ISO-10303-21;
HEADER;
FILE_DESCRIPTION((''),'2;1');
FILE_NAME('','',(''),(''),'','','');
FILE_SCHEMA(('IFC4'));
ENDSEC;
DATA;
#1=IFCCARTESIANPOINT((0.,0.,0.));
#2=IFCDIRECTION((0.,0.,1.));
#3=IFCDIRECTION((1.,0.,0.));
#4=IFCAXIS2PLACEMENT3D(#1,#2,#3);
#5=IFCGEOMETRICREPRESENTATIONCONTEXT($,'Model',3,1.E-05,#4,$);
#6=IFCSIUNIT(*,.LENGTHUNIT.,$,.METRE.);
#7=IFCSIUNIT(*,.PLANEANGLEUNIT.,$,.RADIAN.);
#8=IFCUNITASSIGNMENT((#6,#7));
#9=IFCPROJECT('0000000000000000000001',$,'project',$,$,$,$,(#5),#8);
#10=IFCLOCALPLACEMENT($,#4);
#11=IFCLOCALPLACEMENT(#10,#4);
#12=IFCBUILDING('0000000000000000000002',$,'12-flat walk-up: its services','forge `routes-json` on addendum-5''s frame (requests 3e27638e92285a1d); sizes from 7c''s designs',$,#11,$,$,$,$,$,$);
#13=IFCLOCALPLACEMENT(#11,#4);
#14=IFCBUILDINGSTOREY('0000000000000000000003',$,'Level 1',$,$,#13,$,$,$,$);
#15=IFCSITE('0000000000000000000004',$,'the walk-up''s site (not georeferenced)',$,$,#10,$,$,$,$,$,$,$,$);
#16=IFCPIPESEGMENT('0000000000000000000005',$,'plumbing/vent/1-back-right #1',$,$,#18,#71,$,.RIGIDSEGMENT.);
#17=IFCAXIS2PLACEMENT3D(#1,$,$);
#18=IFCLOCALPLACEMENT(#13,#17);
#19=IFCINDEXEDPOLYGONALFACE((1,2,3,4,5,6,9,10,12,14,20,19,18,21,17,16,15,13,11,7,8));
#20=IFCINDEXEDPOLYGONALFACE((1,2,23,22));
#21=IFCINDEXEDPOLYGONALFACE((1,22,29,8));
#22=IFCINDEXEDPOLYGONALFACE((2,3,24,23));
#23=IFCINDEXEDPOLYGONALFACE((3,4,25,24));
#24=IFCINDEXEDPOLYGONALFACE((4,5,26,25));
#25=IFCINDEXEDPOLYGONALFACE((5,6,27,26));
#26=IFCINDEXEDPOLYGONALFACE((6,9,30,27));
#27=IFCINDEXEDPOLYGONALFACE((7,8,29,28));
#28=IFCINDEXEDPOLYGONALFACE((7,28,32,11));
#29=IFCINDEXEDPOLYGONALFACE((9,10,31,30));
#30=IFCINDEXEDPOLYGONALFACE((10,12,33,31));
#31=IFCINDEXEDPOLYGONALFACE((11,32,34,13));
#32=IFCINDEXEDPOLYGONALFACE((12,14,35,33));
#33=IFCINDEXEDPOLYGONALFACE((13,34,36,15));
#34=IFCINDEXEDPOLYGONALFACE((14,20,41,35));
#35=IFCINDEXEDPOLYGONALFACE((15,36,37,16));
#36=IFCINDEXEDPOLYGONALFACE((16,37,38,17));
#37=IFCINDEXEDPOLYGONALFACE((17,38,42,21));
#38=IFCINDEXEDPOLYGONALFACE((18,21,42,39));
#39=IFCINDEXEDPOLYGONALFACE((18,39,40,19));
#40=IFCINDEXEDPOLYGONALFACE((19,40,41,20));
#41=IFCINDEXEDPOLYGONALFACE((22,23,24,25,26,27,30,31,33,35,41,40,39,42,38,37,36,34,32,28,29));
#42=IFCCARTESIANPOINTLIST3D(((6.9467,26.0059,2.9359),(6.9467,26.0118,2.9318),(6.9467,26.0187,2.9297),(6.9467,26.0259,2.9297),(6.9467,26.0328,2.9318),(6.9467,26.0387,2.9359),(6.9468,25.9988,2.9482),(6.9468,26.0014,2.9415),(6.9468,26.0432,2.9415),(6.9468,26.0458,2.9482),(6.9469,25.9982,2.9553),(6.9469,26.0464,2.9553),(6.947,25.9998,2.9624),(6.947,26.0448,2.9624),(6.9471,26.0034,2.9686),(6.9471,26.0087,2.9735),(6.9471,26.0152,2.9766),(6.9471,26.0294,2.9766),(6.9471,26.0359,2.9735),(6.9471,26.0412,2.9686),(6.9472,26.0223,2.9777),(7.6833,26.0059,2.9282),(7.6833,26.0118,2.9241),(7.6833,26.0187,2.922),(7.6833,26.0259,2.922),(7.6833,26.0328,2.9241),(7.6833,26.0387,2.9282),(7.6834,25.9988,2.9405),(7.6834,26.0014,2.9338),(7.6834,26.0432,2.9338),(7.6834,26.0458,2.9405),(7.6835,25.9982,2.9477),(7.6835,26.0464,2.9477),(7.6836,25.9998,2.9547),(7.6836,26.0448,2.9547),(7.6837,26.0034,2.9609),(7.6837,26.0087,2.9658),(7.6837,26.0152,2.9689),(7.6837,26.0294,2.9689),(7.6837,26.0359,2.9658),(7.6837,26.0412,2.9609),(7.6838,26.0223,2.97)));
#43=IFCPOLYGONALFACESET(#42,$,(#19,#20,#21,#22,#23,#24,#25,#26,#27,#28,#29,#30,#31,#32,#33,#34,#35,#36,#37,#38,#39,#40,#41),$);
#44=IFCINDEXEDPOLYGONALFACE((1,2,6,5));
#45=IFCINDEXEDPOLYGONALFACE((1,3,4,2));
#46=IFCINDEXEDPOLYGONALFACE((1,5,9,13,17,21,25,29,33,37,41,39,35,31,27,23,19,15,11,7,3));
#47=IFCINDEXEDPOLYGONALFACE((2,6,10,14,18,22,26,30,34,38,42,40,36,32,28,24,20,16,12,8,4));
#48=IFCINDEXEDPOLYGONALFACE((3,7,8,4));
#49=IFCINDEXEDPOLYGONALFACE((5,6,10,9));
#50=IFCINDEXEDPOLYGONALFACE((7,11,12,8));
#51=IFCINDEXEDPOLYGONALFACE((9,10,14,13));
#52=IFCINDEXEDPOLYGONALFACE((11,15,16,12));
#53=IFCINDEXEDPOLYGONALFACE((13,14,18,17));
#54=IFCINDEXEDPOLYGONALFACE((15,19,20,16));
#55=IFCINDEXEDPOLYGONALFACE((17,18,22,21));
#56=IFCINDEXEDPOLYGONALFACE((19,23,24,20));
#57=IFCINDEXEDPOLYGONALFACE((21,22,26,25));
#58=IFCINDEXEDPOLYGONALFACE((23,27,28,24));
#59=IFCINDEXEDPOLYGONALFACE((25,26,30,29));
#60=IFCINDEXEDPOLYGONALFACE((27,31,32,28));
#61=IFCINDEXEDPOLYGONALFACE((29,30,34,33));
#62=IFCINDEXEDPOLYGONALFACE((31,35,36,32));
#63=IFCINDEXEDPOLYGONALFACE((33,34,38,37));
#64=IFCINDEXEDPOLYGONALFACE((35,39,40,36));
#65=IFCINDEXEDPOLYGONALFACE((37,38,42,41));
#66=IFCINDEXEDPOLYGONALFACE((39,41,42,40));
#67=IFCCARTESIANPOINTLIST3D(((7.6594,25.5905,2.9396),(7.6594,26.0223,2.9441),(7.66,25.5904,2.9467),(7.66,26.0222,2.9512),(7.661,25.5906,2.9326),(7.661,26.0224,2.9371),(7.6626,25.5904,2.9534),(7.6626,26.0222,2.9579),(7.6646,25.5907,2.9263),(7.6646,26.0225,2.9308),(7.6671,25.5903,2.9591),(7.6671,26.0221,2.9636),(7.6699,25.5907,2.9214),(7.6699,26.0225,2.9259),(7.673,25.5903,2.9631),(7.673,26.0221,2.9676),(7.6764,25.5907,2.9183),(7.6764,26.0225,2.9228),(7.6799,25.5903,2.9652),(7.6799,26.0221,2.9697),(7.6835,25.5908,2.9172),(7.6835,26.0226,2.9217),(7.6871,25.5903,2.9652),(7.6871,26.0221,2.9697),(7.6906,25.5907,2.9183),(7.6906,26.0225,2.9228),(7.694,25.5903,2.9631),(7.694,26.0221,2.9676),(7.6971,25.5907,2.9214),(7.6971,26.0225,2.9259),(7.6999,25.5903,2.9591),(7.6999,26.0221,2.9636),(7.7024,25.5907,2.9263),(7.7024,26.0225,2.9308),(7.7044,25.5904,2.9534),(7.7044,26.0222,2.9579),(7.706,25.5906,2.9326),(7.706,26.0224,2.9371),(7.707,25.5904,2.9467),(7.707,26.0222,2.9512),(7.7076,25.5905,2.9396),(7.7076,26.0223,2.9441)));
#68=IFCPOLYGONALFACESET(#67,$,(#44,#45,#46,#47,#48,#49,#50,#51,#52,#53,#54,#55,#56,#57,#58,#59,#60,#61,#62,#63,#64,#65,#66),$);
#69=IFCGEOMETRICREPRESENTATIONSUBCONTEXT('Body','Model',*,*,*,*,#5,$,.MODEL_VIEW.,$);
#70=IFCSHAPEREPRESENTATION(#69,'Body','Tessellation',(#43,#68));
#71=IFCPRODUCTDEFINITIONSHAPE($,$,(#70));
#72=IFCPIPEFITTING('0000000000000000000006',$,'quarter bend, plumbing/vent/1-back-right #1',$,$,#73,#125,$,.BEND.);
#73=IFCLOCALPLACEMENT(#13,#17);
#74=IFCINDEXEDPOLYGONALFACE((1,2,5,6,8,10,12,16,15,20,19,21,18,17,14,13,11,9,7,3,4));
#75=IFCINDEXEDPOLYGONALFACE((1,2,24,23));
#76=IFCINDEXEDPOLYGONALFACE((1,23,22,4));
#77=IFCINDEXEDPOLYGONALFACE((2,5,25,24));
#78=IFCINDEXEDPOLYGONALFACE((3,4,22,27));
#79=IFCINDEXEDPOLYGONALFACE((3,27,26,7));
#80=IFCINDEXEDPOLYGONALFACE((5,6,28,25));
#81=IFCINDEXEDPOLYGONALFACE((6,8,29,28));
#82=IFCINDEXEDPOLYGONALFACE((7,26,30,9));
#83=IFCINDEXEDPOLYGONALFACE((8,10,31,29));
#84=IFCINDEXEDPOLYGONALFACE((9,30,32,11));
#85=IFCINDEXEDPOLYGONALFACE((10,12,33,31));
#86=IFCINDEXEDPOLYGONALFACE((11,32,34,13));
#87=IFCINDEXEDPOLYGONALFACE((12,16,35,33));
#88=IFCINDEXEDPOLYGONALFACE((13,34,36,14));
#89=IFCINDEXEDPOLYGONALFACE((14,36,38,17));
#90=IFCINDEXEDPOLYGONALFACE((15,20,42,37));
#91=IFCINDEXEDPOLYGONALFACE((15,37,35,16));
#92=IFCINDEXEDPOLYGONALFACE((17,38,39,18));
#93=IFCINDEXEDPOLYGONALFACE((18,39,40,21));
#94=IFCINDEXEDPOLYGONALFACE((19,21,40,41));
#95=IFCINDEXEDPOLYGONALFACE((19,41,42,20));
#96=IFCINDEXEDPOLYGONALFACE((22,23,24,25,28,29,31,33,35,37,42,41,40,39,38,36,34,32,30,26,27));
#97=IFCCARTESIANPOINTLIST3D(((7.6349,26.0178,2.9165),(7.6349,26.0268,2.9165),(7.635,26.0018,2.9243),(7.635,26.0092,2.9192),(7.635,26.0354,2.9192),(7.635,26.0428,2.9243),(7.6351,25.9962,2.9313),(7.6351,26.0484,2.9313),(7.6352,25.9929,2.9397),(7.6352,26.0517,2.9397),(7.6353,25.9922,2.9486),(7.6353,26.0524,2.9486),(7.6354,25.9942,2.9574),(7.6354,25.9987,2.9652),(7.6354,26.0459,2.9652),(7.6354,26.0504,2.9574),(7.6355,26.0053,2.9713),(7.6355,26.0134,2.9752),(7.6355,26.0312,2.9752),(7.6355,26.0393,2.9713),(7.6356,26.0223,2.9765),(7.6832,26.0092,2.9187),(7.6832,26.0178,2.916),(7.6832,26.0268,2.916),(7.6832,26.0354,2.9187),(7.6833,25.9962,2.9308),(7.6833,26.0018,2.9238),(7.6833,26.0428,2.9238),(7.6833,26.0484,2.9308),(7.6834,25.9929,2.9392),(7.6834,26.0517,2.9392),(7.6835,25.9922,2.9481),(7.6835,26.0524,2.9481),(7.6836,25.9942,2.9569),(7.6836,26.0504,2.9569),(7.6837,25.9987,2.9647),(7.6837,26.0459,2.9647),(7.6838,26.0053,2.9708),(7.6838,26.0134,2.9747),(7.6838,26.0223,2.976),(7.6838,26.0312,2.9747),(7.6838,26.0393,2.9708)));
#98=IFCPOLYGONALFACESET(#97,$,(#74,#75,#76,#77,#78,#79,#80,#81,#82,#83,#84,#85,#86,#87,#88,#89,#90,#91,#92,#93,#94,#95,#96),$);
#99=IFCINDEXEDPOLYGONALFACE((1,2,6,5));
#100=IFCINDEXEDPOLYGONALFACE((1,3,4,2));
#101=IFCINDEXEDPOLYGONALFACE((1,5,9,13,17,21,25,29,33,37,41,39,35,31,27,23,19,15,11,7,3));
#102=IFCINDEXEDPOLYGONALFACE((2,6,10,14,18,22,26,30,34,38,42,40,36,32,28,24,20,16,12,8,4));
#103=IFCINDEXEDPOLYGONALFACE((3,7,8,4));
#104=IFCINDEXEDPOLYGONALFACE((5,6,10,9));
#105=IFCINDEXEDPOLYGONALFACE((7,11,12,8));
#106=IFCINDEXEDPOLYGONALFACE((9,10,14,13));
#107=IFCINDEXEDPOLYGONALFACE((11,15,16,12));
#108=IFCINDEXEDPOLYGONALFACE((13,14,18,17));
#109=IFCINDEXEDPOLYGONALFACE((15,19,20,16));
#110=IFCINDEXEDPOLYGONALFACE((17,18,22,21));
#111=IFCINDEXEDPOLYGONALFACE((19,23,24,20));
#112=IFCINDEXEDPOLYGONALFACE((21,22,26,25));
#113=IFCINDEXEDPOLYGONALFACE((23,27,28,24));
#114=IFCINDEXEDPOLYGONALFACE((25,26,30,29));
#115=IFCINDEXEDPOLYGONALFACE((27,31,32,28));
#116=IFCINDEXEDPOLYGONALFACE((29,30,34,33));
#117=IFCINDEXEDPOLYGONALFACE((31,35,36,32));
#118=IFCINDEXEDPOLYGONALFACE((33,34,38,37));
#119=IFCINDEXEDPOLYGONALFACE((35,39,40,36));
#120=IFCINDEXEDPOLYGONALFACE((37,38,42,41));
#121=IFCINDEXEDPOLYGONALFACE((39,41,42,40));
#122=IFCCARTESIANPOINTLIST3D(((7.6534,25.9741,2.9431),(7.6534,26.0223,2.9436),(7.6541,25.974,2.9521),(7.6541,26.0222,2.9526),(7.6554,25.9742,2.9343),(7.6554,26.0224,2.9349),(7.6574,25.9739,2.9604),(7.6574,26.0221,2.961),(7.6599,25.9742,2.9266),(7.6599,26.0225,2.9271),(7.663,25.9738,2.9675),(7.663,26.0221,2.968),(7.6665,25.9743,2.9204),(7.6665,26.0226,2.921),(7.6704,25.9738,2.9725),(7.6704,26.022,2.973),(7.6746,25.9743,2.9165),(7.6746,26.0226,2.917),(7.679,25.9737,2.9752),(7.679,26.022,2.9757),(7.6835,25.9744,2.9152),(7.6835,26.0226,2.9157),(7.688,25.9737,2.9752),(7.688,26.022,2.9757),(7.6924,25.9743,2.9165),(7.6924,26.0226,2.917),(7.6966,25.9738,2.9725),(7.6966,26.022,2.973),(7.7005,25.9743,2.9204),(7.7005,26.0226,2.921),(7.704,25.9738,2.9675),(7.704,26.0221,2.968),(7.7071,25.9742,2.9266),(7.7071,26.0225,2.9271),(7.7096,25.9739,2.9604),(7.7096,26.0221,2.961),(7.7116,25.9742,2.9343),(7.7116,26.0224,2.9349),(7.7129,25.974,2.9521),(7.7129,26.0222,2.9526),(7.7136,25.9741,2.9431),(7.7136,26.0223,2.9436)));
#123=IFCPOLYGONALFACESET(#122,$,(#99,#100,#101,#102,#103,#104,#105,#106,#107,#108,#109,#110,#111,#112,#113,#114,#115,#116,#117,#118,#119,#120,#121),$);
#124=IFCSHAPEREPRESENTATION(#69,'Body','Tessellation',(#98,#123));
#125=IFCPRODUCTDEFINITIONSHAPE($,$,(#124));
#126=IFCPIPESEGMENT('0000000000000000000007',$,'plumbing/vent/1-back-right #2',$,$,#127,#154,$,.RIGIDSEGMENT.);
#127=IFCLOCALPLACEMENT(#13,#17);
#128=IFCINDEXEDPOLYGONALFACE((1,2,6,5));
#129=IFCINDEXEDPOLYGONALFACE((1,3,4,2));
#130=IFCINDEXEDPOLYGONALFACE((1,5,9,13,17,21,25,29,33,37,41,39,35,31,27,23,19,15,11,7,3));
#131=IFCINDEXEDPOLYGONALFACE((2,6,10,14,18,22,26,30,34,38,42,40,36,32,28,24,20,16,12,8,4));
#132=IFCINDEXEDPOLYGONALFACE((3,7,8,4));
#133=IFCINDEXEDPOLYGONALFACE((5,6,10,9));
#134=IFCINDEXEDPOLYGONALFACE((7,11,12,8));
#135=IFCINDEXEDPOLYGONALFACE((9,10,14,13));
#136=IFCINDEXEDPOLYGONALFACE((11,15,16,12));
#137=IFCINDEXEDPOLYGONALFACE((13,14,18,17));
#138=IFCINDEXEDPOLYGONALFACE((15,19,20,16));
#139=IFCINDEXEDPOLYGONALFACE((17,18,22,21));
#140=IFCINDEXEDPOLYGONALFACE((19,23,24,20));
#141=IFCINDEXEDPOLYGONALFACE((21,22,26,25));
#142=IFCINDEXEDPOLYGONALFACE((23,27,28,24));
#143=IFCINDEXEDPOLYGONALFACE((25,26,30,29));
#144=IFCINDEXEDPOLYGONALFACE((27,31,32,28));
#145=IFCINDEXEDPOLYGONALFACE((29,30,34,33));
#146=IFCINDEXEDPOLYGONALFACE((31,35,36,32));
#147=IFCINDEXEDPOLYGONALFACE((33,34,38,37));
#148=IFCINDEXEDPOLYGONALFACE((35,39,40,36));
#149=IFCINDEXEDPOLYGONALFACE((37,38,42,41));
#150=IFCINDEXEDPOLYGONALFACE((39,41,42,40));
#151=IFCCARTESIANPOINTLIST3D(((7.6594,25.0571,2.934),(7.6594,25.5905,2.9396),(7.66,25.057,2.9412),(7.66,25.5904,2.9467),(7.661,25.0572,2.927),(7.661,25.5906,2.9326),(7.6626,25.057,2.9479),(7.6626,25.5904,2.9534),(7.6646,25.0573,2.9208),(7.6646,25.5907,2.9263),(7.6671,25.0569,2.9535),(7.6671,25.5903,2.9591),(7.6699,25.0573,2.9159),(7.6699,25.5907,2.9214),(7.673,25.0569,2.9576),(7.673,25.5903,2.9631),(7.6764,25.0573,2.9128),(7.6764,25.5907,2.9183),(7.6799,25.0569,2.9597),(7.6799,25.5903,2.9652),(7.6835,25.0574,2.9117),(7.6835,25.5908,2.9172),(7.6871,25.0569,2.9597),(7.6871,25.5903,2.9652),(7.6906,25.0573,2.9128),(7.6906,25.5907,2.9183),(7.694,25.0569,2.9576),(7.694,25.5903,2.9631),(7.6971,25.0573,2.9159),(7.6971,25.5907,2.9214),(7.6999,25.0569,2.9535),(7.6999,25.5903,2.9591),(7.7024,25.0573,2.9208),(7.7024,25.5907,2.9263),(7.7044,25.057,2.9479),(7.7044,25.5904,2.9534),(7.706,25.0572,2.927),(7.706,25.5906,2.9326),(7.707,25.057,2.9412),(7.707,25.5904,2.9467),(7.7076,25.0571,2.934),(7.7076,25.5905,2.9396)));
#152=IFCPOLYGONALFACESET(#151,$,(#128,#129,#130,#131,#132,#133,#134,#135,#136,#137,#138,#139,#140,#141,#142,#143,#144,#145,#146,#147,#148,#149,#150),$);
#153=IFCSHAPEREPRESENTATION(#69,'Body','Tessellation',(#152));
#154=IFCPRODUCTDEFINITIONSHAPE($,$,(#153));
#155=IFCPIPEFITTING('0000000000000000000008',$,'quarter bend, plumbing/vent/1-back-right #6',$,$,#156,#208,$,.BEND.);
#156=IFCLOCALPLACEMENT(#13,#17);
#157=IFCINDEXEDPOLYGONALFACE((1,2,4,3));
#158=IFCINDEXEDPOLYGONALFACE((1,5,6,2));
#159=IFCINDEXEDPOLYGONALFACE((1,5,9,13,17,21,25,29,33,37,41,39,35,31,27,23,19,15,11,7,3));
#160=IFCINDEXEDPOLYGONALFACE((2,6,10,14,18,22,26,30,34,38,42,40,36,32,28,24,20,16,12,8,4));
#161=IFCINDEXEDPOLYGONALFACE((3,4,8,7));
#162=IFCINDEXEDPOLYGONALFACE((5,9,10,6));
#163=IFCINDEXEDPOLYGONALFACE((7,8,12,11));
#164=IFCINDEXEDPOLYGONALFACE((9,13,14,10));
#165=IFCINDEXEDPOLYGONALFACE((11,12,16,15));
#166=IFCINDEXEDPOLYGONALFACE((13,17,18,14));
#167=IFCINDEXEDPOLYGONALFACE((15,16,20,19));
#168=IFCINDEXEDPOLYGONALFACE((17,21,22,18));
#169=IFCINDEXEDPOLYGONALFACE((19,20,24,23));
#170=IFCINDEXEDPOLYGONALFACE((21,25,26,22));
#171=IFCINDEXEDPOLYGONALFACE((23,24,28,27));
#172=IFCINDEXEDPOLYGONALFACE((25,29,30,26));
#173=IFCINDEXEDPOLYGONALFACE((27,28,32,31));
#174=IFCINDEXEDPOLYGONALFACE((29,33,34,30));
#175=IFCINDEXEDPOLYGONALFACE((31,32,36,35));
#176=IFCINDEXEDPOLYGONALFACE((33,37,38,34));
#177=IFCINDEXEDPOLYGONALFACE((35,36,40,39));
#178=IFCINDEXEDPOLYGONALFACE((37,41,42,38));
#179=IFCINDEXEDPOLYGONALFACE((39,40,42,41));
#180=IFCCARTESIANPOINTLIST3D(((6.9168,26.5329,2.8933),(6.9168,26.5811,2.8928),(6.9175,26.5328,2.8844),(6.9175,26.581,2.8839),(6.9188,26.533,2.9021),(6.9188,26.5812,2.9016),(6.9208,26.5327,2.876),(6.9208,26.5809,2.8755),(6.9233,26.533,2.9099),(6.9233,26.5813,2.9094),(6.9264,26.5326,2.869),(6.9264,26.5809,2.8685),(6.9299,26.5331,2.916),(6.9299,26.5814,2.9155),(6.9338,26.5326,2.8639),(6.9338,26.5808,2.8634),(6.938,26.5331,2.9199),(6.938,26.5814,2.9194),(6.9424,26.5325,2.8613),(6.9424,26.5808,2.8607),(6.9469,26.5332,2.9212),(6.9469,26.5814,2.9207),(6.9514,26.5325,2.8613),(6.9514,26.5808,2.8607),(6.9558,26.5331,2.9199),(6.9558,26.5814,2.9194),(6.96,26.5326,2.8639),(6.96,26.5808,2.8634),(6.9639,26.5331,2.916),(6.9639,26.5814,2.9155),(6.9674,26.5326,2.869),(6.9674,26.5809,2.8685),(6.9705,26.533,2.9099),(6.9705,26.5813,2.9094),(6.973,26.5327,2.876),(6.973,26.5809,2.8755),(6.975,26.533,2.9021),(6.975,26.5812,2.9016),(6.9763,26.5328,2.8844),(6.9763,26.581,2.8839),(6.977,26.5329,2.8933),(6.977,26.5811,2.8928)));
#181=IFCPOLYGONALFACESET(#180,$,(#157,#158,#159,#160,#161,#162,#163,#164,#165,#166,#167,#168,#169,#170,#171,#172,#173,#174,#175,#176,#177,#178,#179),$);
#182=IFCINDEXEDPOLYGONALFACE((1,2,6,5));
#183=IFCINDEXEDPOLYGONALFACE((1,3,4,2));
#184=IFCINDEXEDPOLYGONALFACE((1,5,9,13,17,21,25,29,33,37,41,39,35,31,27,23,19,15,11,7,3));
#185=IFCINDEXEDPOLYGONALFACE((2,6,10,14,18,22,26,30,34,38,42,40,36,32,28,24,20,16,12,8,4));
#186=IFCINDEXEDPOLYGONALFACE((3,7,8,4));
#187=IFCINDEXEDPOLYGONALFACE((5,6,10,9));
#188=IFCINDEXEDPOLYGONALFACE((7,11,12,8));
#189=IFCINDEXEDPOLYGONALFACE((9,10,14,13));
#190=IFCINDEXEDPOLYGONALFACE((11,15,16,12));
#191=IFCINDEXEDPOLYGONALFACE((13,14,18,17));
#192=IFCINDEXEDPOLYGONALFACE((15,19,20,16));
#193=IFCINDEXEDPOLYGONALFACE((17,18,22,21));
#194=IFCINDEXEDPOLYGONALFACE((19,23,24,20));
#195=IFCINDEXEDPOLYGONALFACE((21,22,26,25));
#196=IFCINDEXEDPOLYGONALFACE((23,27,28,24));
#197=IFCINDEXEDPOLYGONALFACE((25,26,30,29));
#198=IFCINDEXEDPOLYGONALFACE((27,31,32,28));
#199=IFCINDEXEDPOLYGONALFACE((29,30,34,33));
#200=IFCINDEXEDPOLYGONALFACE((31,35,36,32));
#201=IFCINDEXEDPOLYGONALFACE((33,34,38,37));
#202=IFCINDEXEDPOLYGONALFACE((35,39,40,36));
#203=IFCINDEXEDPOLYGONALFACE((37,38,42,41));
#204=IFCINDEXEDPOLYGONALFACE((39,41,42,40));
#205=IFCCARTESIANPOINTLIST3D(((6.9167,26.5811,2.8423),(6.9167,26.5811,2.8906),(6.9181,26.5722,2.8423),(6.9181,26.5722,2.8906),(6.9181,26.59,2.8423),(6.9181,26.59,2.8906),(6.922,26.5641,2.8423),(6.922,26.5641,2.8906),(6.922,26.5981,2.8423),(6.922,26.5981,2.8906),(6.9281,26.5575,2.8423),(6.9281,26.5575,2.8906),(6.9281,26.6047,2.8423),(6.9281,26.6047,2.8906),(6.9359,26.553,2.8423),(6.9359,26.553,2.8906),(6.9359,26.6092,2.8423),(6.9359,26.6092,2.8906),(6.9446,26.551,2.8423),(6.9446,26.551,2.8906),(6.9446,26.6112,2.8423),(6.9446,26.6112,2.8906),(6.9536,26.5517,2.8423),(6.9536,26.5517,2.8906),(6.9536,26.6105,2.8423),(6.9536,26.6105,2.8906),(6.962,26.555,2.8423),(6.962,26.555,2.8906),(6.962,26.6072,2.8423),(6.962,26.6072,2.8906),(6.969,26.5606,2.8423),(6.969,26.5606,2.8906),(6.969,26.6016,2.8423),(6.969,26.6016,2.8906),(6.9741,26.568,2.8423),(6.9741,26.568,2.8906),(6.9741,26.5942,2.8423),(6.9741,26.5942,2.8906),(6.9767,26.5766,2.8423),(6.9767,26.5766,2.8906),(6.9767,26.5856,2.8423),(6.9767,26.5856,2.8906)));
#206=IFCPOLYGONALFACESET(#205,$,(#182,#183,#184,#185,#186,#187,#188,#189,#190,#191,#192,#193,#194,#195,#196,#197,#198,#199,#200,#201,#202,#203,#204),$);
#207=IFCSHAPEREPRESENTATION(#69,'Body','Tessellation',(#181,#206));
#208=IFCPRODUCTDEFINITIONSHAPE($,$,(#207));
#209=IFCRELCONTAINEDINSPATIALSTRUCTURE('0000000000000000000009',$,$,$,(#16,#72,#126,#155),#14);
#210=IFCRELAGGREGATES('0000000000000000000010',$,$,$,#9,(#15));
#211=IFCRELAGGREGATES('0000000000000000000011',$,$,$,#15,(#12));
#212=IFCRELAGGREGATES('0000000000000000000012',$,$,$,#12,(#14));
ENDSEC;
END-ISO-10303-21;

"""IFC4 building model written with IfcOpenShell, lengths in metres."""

from ifc_helpers import new_model, entity, si_unit, frame, origin_with_axes, place, context, subcontext, project, spatial, element, save


model = new_model("IFC4")

# Units and contexts
model_context = context("Model", 3, precision=1e-05, world=origin_with_axes())
body_context = subcontext(model_context, "Body", "Model", "MODEL_VIEW")
ifc_project = project(units=[si_unit("LENGTHUNIT", "METRE"), si_unit("PLANEANGLEUNIT", "RADIAN")], contexts=[model_context])

# Site, building, storey
site_placement = place(None, origin_with_axes())
site = spatial("IfcSite", under=ifc_project, at=site_placement, Name="the walk-up's site (not georeferenced)")
building_placement = place(site_placement, origin_with_axes())
building = spatial("IfcBuilding", under=site, at=building_placement, Name="12-flat walk-up: its services", Description="forge `routes-json` on addendum-5's frame (requests 3e27638e92285a1d); sizes from 7c's designs")
storey_placement = place(building_placement, origin_with_axes())
storey = spatial("IfcBuildingStorey", under=building, at=storey_placement, Name="Level 1")

# Pipe segment
pipe_segment_1_placement = place(storey_placement, frame((6.9469, 26.0223, 2.9535), z_axis=(0.0, 0.0, 1.0), x_axis=(1.0, 0.0, 0.0)))
element("IfcPipeSegment", 1, at=pipe_segment_1_placement, inside=storey, Name="plumbing/vent/1-back-right #1", PredefinedType="RIGIDSEGMENT", context=body_context, shape_type="AdvancedSweptSolid", body=[
    entity("IfcSweptDiskSolid", entity("IfcPolyline", [entity("IfcCartesianPoint", [0.0, 0.0, 0.0]), entity("IfcCartesianPoint", [0.7366, 0.0, -0.0077])]), 0.0241),
    entity("IfcSweptDiskSolid", entity("IfcPolyline", [entity("IfcCartesianPoint", [0.7366, 0.0, -0.0077]), entity("IfcCartesianPoint", [0.7366, -0.4318, -0.0122])]), 0.0241),
])

# Pipe fitting
pipe_fitting_1_placement = place(storey_placement, frame((7.6352, 26.0223, 2.9464), z_axis=(0.0, 0.0, 1.0), x_axis=(1.0, 0.0, 0.0)))
element("IfcPipeFitting", 2, at=pipe_fitting_1_placement, inside=storey, Name="quarter bend, plumbing/vent/1-back-right #1", PredefinedType="BEND", context=body_context, shape_type="AdvancedSweptSolid", body=[
    entity("IfcSweptDiskSolid", entity("IfcPolyline", [entity("IfcCartesianPoint", [0.0, 0.0, 0.0]), entity("IfcCartesianPoint", [0.0483, 0.0, -0.0005])]), 0.0302),
    entity("IfcSweptDiskSolid", entity("IfcPolyline", [entity("IfcCartesianPoint", [0.0483, 0.0, -0.0005]), entity("IfcCartesianPoint", [0.0483, -0.0483, -0.001])]), 0.0302),
])

# Pipe segment
pipe_segment_2_placement = place(storey_placement, frame((7.6835, 25.5905, 2.9414), z_axis=(0.0, 0.0, 1.0), x_axis=(1.0, 0.0, 0.0)))
element("IfcPipeSegment", 3, at=pipe_segment_2_placement, inside=storey, Name="plumbing/vent/1-back-right #2", PredefinedType="RIGIDSEGMENT", context=body_context, shape_type="AdvancedSweptSolid", body=[
    entity("IfcSweptDiskSolid", entity("IfcPolyline", [entity("IfcCartesianPoint", [0.0, 0.0, 0.0]), entity("IfcCartesianPoint", [0.0, -0.5334, -0.0056])]), 0.0241),
])

# Pipe fitting
pipe_fitting_2_placement = place(storey_placement, frame((6.9469, 26.5328, 2.8911), z_axis=(0.0, 0.0, 1.0), x_axis=(1.0, 0.0, 0.0)))
element("IfcPipeFitting", 4, at=pipe_fitting_2_placement, inside=storey, Name="quarter bend, plumbing/vent/1-back-right #6", PredefinedType="BEND", context=body_context, shape_type="AdvancedSweptSolid", body=[
    entity("IfcSweptDiskSolid", entity("IfcPolyline", [entity("IfcCartesianPoint", [0.0, 0.0, 0.0]), entity("IfcCartesianPoint", [0.0, 0.0483, -0.0005])]), 0.0302),
    entity("IfcSweptDiskSolid", entity("IfcPolyline", [entity("IfcCartesianPoint", [0.0, 0.0483, -0.0005]), entity("IfcCartesianPoint", [0.0, 0.0483, -0.0488])]), 0.0302),
])

save(model, "model.ifc")
